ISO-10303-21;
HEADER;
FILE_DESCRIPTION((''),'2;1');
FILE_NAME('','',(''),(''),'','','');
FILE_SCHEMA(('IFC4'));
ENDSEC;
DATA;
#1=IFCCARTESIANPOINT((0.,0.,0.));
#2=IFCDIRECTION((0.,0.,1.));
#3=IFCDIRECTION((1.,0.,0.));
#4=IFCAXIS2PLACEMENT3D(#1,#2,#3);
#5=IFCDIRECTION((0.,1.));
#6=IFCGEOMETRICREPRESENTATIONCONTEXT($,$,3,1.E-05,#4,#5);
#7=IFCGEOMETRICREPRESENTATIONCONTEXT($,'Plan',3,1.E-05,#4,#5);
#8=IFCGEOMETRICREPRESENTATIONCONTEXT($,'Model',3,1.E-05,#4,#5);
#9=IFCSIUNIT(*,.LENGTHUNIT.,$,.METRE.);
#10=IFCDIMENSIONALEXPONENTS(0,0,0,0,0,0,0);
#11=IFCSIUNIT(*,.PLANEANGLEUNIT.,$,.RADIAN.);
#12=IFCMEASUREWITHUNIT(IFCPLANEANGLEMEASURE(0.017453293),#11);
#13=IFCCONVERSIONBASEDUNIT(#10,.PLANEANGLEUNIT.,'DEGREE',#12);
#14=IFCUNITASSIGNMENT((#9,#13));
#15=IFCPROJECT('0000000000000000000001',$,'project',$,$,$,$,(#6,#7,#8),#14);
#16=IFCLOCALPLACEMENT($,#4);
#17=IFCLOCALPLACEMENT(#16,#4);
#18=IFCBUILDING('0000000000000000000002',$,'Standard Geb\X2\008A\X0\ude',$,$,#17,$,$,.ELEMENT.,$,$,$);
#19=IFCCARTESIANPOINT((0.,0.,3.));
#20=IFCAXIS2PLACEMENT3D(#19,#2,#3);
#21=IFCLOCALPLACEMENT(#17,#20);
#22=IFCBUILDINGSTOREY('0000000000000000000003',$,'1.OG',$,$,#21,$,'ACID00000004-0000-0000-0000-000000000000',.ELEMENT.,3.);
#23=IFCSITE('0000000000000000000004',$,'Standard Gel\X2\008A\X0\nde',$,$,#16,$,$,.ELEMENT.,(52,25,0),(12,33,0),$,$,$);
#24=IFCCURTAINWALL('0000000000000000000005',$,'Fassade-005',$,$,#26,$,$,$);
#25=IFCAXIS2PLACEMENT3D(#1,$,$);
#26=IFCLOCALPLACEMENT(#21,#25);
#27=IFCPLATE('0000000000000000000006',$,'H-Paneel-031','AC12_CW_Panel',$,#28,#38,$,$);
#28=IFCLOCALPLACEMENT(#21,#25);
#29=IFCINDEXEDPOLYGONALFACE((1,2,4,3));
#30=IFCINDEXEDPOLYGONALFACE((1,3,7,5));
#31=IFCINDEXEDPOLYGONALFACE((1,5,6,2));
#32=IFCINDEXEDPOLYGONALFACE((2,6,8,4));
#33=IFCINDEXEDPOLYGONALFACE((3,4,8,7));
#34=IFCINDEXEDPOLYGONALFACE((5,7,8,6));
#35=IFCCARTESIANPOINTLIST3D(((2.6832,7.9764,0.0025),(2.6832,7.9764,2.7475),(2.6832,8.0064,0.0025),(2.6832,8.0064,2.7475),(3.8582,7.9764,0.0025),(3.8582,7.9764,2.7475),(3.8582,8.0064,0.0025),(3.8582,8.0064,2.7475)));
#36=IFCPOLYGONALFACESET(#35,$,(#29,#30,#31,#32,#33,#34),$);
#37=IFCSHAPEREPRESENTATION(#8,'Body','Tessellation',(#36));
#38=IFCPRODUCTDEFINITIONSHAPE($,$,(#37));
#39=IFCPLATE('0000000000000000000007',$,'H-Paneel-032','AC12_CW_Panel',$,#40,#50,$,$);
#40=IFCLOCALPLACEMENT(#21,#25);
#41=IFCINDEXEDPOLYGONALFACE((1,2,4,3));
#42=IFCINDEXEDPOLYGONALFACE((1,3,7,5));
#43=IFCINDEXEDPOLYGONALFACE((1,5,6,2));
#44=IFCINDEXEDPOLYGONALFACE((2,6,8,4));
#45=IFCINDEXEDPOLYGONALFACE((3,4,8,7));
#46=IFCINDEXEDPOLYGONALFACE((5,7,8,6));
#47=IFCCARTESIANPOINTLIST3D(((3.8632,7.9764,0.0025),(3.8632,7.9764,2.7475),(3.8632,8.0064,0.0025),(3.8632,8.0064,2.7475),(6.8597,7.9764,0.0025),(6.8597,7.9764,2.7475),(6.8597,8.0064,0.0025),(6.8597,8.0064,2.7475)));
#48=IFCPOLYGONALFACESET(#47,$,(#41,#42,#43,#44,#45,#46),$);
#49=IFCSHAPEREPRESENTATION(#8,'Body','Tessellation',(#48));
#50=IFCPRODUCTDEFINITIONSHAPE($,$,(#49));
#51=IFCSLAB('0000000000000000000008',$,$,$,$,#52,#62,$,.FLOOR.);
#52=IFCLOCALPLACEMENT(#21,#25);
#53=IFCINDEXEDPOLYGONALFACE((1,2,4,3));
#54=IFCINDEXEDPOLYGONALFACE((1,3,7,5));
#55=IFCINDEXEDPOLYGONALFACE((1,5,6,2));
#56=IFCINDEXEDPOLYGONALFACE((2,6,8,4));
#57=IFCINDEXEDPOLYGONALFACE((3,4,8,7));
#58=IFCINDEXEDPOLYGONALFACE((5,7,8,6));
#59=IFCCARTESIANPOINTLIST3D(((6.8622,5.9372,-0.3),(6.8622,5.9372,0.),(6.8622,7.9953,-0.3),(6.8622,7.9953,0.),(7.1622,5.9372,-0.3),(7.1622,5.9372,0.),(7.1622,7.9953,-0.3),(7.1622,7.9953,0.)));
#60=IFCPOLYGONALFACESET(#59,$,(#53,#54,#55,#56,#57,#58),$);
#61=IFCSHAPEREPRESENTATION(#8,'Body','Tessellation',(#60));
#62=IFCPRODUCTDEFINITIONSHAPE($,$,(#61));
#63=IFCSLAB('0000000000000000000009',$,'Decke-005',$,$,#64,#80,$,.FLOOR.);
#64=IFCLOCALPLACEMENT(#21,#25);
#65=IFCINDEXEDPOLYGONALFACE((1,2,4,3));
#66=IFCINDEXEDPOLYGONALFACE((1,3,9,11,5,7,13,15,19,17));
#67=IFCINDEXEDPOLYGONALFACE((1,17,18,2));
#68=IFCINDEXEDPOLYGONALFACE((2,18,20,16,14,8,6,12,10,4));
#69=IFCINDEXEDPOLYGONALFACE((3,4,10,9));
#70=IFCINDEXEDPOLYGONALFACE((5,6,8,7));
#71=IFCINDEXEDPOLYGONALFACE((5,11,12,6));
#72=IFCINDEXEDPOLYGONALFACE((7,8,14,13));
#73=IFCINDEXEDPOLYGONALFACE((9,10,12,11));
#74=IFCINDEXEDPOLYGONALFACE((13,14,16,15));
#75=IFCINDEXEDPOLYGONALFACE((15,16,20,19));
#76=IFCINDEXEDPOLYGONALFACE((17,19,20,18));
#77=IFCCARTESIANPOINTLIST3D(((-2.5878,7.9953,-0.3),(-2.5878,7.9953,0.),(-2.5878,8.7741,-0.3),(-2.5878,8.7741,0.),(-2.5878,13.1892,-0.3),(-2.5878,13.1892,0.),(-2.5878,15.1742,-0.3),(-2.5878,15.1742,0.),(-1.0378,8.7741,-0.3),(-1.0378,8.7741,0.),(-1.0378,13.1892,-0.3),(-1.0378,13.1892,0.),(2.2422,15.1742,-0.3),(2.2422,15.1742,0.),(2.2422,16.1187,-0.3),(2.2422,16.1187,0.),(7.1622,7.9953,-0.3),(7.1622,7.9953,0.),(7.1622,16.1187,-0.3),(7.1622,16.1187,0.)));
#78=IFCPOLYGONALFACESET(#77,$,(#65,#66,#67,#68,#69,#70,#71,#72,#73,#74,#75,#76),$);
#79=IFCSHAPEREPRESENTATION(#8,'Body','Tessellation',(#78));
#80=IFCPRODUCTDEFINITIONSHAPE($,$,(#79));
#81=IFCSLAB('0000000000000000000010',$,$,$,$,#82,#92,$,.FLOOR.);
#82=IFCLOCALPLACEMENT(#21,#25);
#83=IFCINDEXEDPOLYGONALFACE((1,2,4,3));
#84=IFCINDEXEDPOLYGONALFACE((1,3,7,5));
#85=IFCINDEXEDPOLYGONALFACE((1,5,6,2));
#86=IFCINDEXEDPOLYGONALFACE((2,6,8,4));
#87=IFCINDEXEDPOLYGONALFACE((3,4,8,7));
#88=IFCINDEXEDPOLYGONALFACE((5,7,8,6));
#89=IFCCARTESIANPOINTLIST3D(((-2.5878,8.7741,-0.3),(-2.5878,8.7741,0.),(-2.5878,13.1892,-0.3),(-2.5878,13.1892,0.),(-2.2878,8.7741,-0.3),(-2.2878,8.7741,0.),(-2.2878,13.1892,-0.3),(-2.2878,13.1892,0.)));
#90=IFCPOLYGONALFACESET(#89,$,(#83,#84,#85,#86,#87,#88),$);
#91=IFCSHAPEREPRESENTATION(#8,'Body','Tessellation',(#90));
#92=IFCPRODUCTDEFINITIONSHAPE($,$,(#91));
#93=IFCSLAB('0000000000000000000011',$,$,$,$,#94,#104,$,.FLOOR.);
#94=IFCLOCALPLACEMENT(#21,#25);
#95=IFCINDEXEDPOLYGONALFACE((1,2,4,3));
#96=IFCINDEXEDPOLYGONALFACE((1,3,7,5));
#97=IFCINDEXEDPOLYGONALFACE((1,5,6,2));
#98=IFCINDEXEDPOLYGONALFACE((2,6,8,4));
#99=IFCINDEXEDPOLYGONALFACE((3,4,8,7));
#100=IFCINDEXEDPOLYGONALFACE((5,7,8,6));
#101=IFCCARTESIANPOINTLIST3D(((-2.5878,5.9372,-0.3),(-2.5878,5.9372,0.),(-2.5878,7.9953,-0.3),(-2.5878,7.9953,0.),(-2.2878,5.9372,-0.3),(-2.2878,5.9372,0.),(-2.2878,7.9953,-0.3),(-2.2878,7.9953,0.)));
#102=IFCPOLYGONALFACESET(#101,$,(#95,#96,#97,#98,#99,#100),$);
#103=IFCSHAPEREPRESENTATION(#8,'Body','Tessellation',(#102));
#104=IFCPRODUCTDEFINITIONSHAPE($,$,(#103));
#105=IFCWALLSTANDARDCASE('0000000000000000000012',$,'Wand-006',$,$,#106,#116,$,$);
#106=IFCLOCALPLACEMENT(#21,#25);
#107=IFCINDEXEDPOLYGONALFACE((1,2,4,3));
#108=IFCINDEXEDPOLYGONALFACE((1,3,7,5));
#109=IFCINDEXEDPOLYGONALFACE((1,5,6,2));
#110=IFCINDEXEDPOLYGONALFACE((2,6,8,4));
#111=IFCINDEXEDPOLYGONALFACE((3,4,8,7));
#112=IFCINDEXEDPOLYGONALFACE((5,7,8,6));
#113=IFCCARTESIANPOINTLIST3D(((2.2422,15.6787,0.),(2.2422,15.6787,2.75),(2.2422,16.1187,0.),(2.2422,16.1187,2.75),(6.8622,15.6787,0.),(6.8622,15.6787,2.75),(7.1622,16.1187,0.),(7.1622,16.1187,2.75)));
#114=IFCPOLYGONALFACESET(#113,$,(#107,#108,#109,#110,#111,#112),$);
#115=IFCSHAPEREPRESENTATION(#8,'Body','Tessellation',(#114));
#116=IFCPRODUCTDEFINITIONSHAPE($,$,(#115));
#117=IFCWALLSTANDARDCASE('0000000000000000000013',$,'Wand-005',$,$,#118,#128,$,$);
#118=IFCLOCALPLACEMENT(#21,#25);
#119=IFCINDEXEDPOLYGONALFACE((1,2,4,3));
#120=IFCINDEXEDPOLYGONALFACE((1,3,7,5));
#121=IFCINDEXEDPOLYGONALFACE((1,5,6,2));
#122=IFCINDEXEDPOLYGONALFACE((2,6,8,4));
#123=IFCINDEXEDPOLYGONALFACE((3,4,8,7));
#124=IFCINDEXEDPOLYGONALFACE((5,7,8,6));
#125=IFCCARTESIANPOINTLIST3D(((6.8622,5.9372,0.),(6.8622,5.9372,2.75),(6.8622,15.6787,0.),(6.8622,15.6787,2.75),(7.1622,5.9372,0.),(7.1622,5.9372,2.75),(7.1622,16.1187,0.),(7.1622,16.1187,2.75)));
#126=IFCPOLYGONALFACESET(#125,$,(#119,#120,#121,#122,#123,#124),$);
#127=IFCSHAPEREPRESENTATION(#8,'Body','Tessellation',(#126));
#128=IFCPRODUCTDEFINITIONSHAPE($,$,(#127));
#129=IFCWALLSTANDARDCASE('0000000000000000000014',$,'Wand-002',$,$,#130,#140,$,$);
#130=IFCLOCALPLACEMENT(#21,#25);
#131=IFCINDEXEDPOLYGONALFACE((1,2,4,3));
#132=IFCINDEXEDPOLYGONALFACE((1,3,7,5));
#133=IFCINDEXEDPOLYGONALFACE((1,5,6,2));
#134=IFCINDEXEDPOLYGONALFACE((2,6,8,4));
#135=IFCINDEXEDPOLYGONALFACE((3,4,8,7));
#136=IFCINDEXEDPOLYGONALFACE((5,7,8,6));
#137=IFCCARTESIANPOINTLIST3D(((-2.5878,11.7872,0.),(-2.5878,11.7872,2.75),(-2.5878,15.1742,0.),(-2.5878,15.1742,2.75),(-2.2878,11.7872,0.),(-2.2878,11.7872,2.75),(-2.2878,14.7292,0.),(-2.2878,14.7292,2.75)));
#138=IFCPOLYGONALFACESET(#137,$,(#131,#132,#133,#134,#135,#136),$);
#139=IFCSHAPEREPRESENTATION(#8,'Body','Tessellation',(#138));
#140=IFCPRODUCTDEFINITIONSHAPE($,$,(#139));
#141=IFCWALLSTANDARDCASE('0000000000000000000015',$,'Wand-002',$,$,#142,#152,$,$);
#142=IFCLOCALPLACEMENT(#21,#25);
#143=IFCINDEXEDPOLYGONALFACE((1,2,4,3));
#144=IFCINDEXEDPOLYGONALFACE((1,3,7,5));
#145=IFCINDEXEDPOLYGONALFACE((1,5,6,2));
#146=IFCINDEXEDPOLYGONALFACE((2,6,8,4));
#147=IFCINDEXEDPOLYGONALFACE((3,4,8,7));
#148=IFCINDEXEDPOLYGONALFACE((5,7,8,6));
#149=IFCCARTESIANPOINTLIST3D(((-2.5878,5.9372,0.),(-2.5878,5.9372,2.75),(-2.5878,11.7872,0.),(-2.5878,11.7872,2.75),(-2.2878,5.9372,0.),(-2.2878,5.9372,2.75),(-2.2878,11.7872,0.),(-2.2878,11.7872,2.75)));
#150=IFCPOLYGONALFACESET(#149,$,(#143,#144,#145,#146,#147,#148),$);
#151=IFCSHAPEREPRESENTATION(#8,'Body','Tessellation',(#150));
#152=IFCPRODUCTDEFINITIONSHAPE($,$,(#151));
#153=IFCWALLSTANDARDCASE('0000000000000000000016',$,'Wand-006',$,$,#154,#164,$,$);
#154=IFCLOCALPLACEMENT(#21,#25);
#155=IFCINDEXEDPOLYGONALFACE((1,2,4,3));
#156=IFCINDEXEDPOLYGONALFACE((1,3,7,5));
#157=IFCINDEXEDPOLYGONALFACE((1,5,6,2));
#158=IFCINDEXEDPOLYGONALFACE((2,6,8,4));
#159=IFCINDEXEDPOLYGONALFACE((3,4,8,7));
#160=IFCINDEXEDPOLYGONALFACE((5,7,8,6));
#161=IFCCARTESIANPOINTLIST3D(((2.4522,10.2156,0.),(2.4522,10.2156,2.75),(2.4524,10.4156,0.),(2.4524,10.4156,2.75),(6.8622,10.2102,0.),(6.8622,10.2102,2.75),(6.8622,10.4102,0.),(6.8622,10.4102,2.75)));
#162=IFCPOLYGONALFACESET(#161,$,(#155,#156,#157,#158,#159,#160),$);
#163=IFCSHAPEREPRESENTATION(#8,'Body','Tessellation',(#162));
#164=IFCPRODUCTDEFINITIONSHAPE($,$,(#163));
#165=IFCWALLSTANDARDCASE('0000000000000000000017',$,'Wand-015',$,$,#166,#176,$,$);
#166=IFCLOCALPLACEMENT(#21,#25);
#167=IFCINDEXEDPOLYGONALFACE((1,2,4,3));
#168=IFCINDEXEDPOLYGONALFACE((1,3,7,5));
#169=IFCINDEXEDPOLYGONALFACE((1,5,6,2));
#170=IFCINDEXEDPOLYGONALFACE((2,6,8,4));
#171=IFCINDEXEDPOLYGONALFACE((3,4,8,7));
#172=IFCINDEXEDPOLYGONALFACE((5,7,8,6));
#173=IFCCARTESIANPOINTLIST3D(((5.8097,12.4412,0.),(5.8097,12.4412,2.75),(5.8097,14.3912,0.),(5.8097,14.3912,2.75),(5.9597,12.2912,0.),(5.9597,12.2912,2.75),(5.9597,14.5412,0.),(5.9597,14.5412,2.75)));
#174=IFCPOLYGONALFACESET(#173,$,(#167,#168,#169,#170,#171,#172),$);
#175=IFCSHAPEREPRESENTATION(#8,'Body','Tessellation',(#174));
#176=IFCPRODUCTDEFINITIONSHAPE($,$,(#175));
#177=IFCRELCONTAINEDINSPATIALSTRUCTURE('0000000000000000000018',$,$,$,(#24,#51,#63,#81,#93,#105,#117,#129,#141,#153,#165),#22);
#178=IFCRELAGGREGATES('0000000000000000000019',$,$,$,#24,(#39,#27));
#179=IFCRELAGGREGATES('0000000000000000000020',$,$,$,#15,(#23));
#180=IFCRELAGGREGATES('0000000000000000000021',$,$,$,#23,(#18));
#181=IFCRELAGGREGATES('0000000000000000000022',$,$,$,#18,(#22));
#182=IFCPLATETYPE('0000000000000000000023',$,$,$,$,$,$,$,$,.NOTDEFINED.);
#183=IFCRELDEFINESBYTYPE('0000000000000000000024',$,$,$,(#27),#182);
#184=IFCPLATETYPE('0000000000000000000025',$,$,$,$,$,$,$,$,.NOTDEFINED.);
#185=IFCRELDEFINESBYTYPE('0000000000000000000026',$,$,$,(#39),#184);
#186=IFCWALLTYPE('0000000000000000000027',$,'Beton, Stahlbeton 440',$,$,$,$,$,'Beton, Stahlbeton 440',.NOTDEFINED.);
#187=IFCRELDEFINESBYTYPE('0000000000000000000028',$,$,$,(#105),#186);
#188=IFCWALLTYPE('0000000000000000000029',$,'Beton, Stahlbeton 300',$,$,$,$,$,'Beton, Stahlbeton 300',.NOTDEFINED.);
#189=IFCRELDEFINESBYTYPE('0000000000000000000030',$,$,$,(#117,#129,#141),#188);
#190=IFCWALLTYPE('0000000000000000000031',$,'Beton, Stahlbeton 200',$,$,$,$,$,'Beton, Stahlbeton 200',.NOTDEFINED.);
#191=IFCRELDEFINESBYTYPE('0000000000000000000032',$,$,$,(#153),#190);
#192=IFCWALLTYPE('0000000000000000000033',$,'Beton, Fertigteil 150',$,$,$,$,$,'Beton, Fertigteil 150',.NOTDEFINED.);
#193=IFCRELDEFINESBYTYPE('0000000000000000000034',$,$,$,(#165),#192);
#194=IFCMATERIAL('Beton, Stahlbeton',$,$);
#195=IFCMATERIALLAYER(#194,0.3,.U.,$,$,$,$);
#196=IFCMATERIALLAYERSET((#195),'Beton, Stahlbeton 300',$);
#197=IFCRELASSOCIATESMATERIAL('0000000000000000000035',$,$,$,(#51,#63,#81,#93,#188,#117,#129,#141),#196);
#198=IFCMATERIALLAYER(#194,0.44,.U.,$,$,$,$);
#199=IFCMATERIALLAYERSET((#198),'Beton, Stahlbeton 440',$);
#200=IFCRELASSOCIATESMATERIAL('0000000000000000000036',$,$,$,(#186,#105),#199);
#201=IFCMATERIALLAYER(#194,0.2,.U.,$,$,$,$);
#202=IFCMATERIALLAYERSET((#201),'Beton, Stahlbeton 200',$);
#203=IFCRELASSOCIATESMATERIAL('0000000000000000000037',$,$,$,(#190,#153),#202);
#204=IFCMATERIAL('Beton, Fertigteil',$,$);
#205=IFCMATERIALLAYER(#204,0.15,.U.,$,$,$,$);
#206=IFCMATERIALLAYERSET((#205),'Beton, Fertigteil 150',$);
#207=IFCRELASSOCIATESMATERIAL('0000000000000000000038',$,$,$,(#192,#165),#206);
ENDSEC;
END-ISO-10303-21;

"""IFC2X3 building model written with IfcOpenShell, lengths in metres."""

from ifc_helpers import new_model, entity, si_unit, converted_unit, direction, frame, origin_with_axes, place, context, project, spatial, polyline, outline, extrude, source, transform, mapped, material, layer, layer_set, layer_usage, type_object, type_shapes, element, aggregate, save


model = new_model("IFC2X3")

# Units and contexts
model_context = context("Model", 3, precision=1e-05, world=origin_with_axes(), true_north=direction((0.0, 1.0)))
plan_context = context("Plan", 3, precision=1e-05, world=origin_with_axes(), true_north=direction((0.0, 1.0)))
context_of_model = context(None, 3, precision=1e-05, world=origin_with_axes(), true_north=direction((0.0, 1.0)))
ifc_project = project(units=[si_unit("LENGTHUNIT", "METRE"), converted_unit("PLANEANGLEUNIT", "DEGREE", entity("IfcPlaneAngleMeasure", 0.017453293), si_unit("PLANEANGLEUNIT", "RADIAN"), dimensions=[0, 0, 0, 0, 0, 0, 0])], contexts=[context_of_model, plan_context, model_context])

# Site, building, storey
site_placement = place(None, origin_with_axes())
site = spatial("IfcSite", under=ifc_project, at=site_placement, Name="Standard Gel\u008ande", CompositionType="ELEMENT", RefLatitude=(52, 25, 0), RefLongitude=(12, 33, 0))
building_placement = place(site_placement, origin_with_axes())
building = spatial("IfcBuilding", under=site, at=building_placement, Name="Standard Geb\u008aude", CompositionType="ELEMENT")
storey_placement = place(building_placement, frame((0.0, 0.0, 3.0), z_axis=(0.0, 0.0, 1.0), x_axis=(1.0, 0.0, 0.0)))
storey = spatial("IfcBuildingStorey", under=building, at=storey_placement, Name="1.OG", LongName="ACID00000004-0000-0000-0000-000000000000", CompositionType="ELEMENT", Elevation=3.0)

# Curtain wall, plates
curtain_wall_placement = place(storey_placement, frame((2.6807, 7.9914, 0.0), z_axis=(0.0, 0.0, 1.0), x_axis=(1.0, 0.0, 0.0)))
curtain_wall = element("IfcCurtainWall", 1, at=curtain_wall_placement, inside=storey, Name="Fassade-005")
plate_type_1 = type_object("IfcPlateType", PredefinedType="NOTDEFINED")
shared_shape_1 = source(origin_with_axes(), model_context, "Body", "SweptSolid", [
    extrude(outline(polyline([(0.0, 0.0), (1.175, 0.0), (1.175, -0.03), (0.0, -0.03), (0.0, 0.0)])), origin_with_axes(), (0.0, 0.0, 1.0), 2.745),
])
type_shapes(plate_type_1, [shared_shape_1])
plate_1_placement = place(storey_placement, frame((2.6832, 8.0064, 0.0025), z_axis=(0.0, 0.0, 1.0), x_axis=(1.0, 0.0, 0.0)))
plate_1 = element("IfcPlate", 2, at=plate_1_placement, type_object=plate_type_1, Name="H-Paneel-031", Description="AC12_CW_Panel", context=model_context, shape_type="MappedRepresentation", body=[
    mapped(shared_shape_1, transform((0.0, 0.0, 0.0), scale=1.0)),
])
plate_type_2 = type_object("IfcPlateType", PredefinedType="NOTDEFINED")
shared_shape_2 = source(origin_with_axes(), model_context, "Body", "SweptSolid", [
    extrude(outline(polyline([(0.0, 0.0), (2.9965, 0.0), (2.9965, -0.03), (0.0, -0.03), (0.0, 0.0)])), origin_with_axes(), (0.0, 0.0, 1.0), 2.745),
])
type_shapes(plate_type_2, [shared_shape_2])
plate_2_placement = place(storey_placement, frame((3.8632, 8.0064, 0.0025), z_axis=(0.0, 0.0, 1.0), x_axis=(1.0, 0.0, 0.0)))
plate_2 = element("IfcPlate", 3, at=plate_2_placement, type_object=plate_type_2, Name="H-Paneel-032", Description="AC12_CW_Panel", context=model_context, shape_type="MappedRepresentation", body=[
    mapped(shared_shape_2, transform((0.0, 0.0, 0.0), scale=1.0)),
])

# Slabs
ifc_material_1 = material(Name="Beton, Stahlbeton")
ifc_layer_1 = layer(ifc_material_1, 0.3, ventilated="UNKNOWN")
ifc_layer_set_1 = layer_set([ifc_layer_1], Name="Beton, Stahlbeton 300")
ifc_layer_usage_1 = layer_usage(ifc_layer_set_1, "AXIS3", "NEGATIVE", 0.3)
slab_1_placement = place(storey_placement, frame((6.8622, 7.9953, -0.3), z_axis=(0.0, 0.0, 1.0), x_axis=(0.0, -1.0, 0.0)))
element("IfcSlab", 4, at=slab_1_placement, inside=storey, material=ifc_layer_usage_1, PredefinedType="FLOOR", context=model_context, shape_type="SweptSolid", body=[
    extrude(outline(polyline([(0.0, 0.0), (2.0581, 0.0), (2.0581, 0.3), (0.0, 0.3), (0.0, 0.0)])), origin_with_axes(), (0.0, 0.0, 1.0), 0.3),
])
ifc_layer_usage_2 = layer_usage(ifc_layer_set_1, "AXIS3", "NEGATIVE", 0.3)
slab_2_placement = place(storey_placement, frame((-2.5878, 15.1742, -0.3), z_axis=(0.0, 0.0, 1.0), x_axis=(1.0, 0.0, 0.0)))
element("IfcSlab", 5, at=slab_2_placement, inside=storey, material=ifc_layer_usage_2, Name="Decke-005", PredefinedType="FLOOR", context=model_context, shape_type="SweptSolid", body=[
    extrude(outline(polyline([(0.0, 0.0), (4.83, 0.0), (4.83, 0.9445), (9.75, 0.9445), (9.75, -7.1789), (0.0, -7.1789), (0.0, -6.4001), (1.55, -6.4001), (1.55, -1.985), (0.0, -1.985), (0.0, 0.0)])), origin_with_axes(), (0.0, 0.0, 1.0), 0.3),
])
ifc_layer_usage_3 = layer_usage(ifc_layer_set_1, "AXIS3", "NEGATIVE", 0.3)
slab_3_placement = place(storey_placement, frame((-2.2878, 13.1892, -0.3), z_axis=(0.0, 0.0, 1.0), x_axis=(-1.0, 0.0, 0.0)))
element("IfcSlab", 6, at=slab_3_placement, inside=storey, material=ifc_layer_usage_3, PredefinedType="FLOOR", context=model_context, shape_type="SweptSolid", body=[
    extrude(outline(polyline([(0.0, 0.0), (0.3, 0.0), (0.3, 4.4151), (0.0, 4.4151), (0.0, 0.0)])), origin_with_axes(), (0.0, 0.0, 1.0), 0.3),
])
ifc_layer_usage_4 = layer_usage(ifc_layer_set_1, "AXIS3", "NEGATIVE", 0.3)
slab_4_placement = place(storey_placement, frame((-2.2878, 7.9953, -0.3), z_axis=(0.0, 0.0, 1.0), x_axis=(0.0, -1.0, 0.0)))
element("IfcSlab", 7, at=slab_4_placement, inside=storey, material=ifc_layer_usage_4, PredefinedType="FLOOR", context=model_context, shape_type="SweptSolid", body=[
    extrude(outline(polyline([(0.0, 0.0), (2.0581, 0.0), (2.0581, -0.3), (0.0, -0.3), (0.0, 0.0)])), origin_with_axes(), (0.0, 0.0, 1.0), 0.3),
])

# Walls
ifc_layer_2 = layer(ifc_material_1, 0.44, ventilated="UNKNOWN")
ifc_layer_set_2 = layer_set([ifc_layer_2], Name="Beton, Stahlbeton 440")
ifc_layer_usage_5 = layer_usage(ifc_layer_set_2, "AXIS2", "POSITIVE", 0.0)
wall_type_1 = type_object("IfcWallType", Name="Beton, Stahlbeton 440", ElementType="Beton, Stahlbeton 440", PredefinedType="NOTDEFINED", material=ifc_layer_set_2)
wall_1_placement = place(storey_placement, frame((7.1622, 16.1187, 0.0), z_axis=(0.0, 0.0, 1.0), x_axis=(-1.0, 0.0, 0.0)))
element("IfcWallStandardCase", 8, at=wall_1_placement, inside=storey, type_object=wall_type_1, material=ifc_layer_usage_5, Name="Wand-006", context=model_context, shape_type="SweptSolid", body=[
    extrude(outline(polyline([(0.0, 0.0), (4.92, 0.0), (4.92, 0.44), (0.3, 0.44), (0.0, 0.0)])), origin_with_axes(), (0.0, 0.0, 1.0), 2.75),
])
ifc_layer_usage_6 = layer_usage(ifc_layer_set_1, "AXIS2", "POSITIVE", 0.0)
wall_type_2 = type_object("IfcWallType", Name="Beton, Stahlbeton 300", ElementType="Beton, Stahlbeton 300", PredefinedType="NOTDEFINED", material=ifc_layer_set_1)
wall_2_placement = place(storey_placement, frame((7.1622, 5.9372, 0.0), z_axis=(0.0, 0.0, 1.0), x_axis=(0.0, 1.0, 0.0)))
element("IfcWallStandardCase", 9, at=wall_2_placement, inside=storey, type_object=wall_type_2, material=ifc_layer_usage_6, Name="Wand-005", context=model_context, shape_type="SweptSolid", body=[
    extrude(outline(polyline([(0.0, 0.0), (10.1815, 0.0), (9.7415, 0.3), (0.0, 0.3), (0.0, 0.0)])), origin_with_axes(), (0.0, 0.0, 1.0), 2.75),
])
ifc_layer_usage_7 = layer_usage(ifc_layer_set_1, "AXIS2", "POSITIVE", 0.0)
wall_3_placement = place(storey_placement, frame((-2.5878, 15.1742, 0.0), z_axis=(0.0, 0.0, 1.0), x_axis=(0.0, -1.0, 0.0)))
element("IfcWallStandardCase", 10, at=wall_3_placement, inside=storey, type_object=wall_type_2, material=ifc_layer_usage_7, Name="Wand-002", context=model_context, shape_type="SweptSolid", body=[
    extrude(outline(polyline([(0.0, 0.0), (3.387, 0.0), (3.387, 0.3), (0.445, 0.3), (0.0, 0.0)])), origin_with_axes(), (0.0, 0.0, 1.0), 2.75),
])
ifc_layer_usage_8 = layer_usage(ifc_layer_set_1, "AXIS2", "POSITIVE", 0.0)
wall_4_placement = place(storey_placement, frame((-2.5878, 11.7872, 0.0), z_axis=(0.0, 0.0, 1.0), x_axis=(0.0, -1.0, 0.0)))
element("IfcWallStandardCase", 11, at=wall_4_placement, inside=storey, type_object=wall_type_2, material=ifc_layer_usage_8, Name="Wand-002", context=model_context, shape_type="SweptSolid", body=[
    extrude(outline(polyline([(0.0, 0.0), (5.85, 0.0), (5.85, 0.3), (0.0, 0.3), (0.0, 0.0)])), origin_with_axes(), (0.0, 0.0, 1.0), 2.75),
])
ifc_layer_3 = layer(ifc_material_1, 0.2, ventilated="UNKNOWN")
ifc_layer_set_3 = layer_set([ifc_layer_3], Name="Beton, Stahlbeton 200")
ifc_layer_usage_9 = layer_usage(ifc_layer_set_3, "AXIS2", "POSITIVE", 0.0)
wall_type_3 = type_object("IfcWallType", Name="Beton, Stahlbeton 200", ElementType="Beton, Stahlbeton 200", PredefinedType="NOTDEFINED", material=ifc_layer_set_3)
wall_5_placement = place(storey_placement, frame((2.4522, 10.2156, 0.0), z_axis=(0.0, 0.0, 1.0), x_axis=(0.999999, -0.001239, 0.0)))
element("IfcWallStandardCase", 12, at=wall_5_placement, inside=storey, type_object=wall_type_3, material=ifc_layer_usage_9, Name="Wand-006", context=model_context, shape_type="SweptSolid", body=[
    extrude(outline(polyline([(0.0, 0.0), (4.41, 0.0), (4.4098, 0.2), (0.0, 0.2), (0.0, 0.0)])), origin_with_axes(), (0.0, 0.0, 1.0), 2.75),
])
ifc_material_2 = material(Name="Beton, Fertigteil")
ifc_layer_4 = layer(ifc_material_2, 0.15, ventilated="UNKNOWN")
ifc_layer_set_4 = layer_set([ifc_layer_4], Name="Beton, Fertigteil 150")
ifc_layer_usage_10 = layer_usage(ifc_layer_set_4, "AXIS2", "NEGATIVE", 0.0)
wall_type_4 = type_object("IfcWallType", Name="Beton, Fertigteil 150", ElementType="Beton, Fertigteil 150", PredefinedType="NOTDEFINED", material=ifc_layer_set_4)
wall_6_placement = place(storey_placement, frame((5.9597, 14.5412, 0.0), z_axis=(0.0, 0.0, 1.0), x_axis=(0.0, -1.0, 0.0)))
element("IfcWallStandardCase", 13, at=wall_6_placement, inside=storey, type_object=wall_type_4, material=ifc_layer_usage_10, Name="Wand-015", context=model_context, shape_type="SweptSolid", body=[
    extrude(outline(polyline([(0.15, -0.15), (2.1, -0.15), (2.25, 0.0), (0.0, 0.0), (0.15, -0.15)])), origin_with_axes(), (0.0, 0.0, 1.0), 2.75),
])

aggregate(curtain_wall, [plate_2, plate_1])

save(model, "model.ifc")
